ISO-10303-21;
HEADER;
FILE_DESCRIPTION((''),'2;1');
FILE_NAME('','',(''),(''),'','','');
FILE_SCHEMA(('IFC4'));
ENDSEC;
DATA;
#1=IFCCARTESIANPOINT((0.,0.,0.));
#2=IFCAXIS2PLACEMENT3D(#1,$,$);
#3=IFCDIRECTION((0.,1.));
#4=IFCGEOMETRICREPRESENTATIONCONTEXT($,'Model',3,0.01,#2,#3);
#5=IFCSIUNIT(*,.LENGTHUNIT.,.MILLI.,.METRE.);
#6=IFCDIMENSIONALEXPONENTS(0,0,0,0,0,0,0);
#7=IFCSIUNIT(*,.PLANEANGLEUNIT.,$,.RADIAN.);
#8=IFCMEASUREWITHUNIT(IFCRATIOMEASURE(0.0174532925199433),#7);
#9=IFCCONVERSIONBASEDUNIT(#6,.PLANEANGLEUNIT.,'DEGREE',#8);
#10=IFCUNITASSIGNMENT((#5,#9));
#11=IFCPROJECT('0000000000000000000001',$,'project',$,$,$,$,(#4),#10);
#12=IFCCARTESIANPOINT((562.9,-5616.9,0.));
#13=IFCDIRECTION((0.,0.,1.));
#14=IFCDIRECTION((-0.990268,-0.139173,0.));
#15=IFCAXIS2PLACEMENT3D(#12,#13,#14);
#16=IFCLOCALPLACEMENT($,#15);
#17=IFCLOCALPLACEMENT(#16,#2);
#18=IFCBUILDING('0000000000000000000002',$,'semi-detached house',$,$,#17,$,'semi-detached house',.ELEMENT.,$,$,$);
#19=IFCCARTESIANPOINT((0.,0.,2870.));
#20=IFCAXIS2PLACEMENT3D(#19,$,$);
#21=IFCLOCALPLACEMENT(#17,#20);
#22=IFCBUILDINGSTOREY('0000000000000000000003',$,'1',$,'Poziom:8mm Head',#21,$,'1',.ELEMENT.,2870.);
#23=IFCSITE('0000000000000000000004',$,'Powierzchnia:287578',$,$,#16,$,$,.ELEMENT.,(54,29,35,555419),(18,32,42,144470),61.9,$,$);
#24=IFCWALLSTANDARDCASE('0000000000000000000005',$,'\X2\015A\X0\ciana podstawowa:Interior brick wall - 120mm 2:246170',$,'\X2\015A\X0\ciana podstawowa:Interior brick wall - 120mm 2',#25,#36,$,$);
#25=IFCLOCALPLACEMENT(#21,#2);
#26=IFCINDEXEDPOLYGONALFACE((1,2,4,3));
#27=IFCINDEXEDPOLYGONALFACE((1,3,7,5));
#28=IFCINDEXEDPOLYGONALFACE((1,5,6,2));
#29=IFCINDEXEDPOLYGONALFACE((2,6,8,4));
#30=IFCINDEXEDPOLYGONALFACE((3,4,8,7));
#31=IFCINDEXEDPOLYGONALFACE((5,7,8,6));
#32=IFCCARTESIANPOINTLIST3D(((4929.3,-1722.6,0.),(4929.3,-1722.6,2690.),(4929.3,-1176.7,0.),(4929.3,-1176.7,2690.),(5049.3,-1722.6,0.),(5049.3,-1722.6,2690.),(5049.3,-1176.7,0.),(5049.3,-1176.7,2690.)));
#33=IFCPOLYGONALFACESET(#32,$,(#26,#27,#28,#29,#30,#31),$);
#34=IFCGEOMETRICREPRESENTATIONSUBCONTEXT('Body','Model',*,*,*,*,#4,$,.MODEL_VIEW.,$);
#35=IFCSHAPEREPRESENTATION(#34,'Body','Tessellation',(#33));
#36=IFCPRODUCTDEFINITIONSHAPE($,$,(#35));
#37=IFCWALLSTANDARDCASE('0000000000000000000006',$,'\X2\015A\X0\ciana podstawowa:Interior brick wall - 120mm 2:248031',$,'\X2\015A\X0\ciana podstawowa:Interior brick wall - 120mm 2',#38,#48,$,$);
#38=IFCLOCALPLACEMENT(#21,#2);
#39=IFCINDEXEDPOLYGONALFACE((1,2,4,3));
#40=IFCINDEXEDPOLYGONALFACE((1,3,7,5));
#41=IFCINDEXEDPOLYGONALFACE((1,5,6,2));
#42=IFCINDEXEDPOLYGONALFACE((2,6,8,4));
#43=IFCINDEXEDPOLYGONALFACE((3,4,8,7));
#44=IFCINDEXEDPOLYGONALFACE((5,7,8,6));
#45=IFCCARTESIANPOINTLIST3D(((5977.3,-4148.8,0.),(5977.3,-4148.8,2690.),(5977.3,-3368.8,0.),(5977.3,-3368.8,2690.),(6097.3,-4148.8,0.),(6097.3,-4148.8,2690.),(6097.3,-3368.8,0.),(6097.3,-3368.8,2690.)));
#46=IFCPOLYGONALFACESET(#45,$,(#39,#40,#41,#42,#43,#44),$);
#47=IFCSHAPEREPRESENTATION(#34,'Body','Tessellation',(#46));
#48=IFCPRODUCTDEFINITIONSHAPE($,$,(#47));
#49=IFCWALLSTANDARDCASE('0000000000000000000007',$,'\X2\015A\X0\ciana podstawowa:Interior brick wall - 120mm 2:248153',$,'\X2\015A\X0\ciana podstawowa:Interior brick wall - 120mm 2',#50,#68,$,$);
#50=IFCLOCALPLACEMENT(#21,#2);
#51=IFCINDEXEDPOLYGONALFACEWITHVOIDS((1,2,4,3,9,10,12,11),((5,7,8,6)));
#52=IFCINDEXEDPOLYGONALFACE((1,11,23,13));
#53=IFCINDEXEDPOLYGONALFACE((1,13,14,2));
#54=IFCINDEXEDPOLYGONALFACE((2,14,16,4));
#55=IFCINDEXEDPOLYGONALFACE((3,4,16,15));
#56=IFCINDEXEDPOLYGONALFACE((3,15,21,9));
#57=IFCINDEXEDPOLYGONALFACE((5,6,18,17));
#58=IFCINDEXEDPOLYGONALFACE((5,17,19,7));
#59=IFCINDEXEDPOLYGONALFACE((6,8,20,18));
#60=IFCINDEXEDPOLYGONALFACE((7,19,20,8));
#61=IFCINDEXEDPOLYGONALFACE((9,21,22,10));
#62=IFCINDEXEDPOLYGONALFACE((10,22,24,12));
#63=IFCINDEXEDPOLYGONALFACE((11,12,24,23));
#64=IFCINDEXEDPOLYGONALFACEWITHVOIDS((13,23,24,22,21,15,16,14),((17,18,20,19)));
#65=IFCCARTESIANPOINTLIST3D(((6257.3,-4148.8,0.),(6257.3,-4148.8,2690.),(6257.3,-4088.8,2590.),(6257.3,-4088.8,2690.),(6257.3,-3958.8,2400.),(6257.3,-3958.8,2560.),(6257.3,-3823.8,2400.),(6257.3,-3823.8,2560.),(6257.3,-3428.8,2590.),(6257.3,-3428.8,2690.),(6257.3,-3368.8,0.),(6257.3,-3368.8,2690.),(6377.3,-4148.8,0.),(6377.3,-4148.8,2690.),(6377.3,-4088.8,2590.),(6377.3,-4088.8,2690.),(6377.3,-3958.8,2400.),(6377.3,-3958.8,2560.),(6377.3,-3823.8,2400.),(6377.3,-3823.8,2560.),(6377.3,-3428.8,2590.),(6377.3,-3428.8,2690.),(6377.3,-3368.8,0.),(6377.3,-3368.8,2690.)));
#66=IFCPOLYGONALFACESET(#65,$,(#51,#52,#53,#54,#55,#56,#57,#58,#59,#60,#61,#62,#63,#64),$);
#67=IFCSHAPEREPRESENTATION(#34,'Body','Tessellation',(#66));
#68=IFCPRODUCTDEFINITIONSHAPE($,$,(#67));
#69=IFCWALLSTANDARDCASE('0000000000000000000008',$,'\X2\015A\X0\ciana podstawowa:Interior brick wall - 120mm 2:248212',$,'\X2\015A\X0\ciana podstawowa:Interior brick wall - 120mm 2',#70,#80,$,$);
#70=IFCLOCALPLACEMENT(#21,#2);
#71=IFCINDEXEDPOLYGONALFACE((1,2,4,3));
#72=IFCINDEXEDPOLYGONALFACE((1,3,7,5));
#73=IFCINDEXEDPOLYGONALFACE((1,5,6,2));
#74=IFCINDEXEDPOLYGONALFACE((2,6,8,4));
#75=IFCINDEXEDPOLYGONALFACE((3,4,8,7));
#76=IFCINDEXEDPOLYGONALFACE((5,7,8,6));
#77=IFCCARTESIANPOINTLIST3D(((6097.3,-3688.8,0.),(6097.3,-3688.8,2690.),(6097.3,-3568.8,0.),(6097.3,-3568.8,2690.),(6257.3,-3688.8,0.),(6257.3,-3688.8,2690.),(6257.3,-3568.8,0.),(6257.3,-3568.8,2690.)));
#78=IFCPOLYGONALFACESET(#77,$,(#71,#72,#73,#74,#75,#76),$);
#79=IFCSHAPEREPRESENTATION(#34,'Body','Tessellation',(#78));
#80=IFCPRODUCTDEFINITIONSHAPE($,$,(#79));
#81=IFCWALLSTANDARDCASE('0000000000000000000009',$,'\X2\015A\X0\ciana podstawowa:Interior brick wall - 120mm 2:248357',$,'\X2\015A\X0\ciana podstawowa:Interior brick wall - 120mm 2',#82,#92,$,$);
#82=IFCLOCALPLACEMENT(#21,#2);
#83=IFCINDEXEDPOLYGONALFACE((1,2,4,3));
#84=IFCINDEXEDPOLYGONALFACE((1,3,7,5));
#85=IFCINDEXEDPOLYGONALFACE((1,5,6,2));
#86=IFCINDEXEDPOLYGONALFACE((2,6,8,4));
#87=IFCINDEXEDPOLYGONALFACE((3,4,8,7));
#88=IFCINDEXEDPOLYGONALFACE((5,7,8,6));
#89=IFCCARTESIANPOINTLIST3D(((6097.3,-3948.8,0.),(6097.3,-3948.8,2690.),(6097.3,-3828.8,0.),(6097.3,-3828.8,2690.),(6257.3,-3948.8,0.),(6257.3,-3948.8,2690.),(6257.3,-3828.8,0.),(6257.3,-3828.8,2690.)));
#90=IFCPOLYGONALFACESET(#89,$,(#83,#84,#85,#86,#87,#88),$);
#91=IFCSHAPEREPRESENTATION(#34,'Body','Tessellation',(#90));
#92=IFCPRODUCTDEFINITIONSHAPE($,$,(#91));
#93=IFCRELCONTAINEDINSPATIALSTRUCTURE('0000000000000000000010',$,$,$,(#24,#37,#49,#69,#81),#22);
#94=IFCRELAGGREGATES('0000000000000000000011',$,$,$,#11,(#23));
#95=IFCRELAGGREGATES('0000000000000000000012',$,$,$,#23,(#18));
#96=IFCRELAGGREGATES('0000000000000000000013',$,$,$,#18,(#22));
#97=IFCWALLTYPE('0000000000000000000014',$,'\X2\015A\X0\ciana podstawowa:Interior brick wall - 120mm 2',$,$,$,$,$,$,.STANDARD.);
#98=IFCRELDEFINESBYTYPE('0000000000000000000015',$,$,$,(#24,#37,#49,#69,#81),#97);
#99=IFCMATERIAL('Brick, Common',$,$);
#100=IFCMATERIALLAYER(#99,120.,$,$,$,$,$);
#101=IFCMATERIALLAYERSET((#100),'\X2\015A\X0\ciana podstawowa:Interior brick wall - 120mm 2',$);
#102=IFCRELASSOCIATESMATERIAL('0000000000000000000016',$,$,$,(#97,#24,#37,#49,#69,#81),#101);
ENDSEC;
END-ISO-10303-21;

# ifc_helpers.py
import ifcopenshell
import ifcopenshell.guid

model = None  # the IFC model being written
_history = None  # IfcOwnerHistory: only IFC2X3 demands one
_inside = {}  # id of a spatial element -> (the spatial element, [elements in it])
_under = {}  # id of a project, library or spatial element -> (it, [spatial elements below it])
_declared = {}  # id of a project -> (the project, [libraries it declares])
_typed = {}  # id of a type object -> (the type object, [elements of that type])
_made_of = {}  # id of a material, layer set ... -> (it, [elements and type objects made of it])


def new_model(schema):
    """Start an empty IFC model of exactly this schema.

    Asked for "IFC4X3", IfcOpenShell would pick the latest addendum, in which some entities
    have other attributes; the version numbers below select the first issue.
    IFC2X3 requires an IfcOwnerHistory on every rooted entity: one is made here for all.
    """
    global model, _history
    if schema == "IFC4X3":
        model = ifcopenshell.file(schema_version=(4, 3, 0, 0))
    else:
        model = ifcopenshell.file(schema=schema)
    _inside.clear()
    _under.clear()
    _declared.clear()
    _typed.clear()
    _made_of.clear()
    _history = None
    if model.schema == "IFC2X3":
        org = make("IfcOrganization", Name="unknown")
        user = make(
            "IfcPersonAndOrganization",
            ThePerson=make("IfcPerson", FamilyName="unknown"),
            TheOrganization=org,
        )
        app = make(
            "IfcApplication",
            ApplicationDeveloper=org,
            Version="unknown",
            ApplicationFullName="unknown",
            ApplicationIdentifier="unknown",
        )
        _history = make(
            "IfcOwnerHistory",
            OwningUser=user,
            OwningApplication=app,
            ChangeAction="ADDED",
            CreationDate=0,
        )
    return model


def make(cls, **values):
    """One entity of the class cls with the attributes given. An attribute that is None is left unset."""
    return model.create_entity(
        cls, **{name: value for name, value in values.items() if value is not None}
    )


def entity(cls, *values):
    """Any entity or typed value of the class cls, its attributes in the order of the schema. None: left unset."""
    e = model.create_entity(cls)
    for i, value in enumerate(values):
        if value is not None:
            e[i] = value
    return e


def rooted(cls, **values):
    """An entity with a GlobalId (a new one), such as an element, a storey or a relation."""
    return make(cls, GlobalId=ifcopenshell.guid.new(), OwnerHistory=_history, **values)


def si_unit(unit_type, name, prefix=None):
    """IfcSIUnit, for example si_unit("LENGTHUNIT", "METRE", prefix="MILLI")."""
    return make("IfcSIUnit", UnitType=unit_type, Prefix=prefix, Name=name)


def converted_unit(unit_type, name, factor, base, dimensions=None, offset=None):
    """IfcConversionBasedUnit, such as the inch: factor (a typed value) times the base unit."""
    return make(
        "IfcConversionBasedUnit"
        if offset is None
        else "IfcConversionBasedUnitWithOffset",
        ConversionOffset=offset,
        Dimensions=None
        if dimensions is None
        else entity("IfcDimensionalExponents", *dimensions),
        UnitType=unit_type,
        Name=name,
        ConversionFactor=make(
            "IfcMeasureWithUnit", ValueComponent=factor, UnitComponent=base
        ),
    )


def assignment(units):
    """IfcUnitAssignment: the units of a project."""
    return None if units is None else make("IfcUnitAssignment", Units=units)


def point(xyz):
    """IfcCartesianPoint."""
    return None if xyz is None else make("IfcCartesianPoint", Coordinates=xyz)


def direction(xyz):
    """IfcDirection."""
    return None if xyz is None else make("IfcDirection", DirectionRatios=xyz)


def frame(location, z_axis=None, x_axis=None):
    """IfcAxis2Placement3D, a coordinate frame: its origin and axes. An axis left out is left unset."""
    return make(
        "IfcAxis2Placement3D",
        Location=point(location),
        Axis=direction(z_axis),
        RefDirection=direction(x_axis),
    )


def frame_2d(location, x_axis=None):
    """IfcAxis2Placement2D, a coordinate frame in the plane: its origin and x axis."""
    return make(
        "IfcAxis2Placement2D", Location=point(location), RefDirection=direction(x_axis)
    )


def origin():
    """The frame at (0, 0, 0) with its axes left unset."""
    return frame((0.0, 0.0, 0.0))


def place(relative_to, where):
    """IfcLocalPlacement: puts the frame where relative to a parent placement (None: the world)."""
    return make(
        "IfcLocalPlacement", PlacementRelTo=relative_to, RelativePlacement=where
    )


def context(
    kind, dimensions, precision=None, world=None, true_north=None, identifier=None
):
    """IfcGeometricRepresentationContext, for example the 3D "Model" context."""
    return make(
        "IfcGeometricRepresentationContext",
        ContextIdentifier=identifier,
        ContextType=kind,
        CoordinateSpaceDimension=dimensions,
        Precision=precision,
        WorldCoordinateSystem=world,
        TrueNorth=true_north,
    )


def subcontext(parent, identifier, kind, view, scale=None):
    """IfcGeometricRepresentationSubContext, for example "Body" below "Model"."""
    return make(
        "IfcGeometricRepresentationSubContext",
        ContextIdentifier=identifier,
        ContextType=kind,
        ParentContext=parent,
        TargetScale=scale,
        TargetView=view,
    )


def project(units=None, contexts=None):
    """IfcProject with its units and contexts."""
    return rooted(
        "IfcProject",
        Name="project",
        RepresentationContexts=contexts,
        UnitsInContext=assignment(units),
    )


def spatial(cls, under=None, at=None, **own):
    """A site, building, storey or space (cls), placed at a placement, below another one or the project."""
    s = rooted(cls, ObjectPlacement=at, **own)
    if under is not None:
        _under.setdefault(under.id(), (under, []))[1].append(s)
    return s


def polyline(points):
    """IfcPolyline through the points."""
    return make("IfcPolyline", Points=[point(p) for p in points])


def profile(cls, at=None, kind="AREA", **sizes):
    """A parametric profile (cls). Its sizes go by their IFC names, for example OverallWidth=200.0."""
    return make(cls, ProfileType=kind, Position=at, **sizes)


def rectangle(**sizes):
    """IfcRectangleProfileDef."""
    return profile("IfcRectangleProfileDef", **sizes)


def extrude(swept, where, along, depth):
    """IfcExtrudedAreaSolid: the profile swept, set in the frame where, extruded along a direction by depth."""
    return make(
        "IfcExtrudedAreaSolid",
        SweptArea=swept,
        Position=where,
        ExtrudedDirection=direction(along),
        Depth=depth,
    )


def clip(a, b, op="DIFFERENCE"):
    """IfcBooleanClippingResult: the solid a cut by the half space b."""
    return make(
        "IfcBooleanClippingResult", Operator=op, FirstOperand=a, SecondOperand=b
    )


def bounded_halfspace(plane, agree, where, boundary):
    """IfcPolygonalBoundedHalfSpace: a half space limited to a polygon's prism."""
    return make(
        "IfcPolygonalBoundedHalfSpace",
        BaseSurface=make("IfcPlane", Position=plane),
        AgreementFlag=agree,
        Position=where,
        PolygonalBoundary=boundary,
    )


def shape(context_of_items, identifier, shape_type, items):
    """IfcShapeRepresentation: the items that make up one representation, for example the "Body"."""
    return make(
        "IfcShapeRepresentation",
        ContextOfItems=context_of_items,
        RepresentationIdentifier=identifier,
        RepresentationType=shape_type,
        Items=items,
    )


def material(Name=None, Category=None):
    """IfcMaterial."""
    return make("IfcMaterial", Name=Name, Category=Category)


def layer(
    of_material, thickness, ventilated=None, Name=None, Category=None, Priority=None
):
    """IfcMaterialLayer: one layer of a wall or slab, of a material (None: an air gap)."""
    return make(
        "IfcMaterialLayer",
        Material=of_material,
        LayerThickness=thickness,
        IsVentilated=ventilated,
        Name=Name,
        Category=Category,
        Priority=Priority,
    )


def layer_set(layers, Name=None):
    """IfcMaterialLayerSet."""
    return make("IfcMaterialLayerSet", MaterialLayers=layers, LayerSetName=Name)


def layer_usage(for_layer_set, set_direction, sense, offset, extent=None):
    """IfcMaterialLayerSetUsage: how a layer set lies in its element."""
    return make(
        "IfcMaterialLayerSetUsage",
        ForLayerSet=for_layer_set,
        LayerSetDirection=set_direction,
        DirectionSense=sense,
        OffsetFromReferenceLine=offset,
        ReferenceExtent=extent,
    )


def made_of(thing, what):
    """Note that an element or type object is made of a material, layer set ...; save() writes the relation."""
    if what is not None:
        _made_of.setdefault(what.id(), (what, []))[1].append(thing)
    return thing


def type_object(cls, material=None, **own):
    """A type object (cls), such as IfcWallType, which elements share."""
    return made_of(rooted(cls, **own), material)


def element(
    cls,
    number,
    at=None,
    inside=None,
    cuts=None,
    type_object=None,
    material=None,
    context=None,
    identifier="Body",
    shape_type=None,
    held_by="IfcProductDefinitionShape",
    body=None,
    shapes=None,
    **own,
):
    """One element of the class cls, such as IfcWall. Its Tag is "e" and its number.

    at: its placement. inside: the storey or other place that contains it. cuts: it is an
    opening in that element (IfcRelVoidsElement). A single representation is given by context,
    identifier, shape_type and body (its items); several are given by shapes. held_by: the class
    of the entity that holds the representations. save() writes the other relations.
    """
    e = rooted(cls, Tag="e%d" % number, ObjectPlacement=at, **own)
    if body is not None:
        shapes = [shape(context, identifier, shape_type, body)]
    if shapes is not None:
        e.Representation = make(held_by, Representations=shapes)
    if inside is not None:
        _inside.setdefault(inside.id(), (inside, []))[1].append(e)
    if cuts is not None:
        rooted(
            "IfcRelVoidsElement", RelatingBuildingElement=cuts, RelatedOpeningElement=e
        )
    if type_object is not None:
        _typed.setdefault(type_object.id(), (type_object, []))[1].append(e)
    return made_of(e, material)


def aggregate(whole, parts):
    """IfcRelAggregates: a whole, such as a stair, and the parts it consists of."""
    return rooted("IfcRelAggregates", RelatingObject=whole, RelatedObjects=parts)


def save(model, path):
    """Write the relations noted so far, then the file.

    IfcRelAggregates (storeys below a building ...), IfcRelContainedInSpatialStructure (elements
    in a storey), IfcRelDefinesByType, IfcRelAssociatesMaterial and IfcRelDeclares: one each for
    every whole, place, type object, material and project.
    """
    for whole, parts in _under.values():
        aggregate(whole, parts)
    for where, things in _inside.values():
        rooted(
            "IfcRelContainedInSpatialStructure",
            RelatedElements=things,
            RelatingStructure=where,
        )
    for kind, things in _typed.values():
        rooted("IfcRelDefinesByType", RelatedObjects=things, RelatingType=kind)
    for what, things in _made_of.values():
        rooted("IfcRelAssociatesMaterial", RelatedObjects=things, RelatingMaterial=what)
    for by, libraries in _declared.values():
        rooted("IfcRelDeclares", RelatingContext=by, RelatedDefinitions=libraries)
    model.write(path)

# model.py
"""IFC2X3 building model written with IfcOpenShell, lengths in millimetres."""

from ifc_helpers import new_model, entity, si_unit, converted_unit, direction, frame, frame_2d, origin, place, context, subcontext, project, spatial, polyline, rectangle, extrude, clip, bounded_halfspace, material, layer, layer_set, layer_usage, type_object, element, save


model = new_model("IFC2X3")

# Units and contexts
model_context = context("Model", 3, precision=0.01, world=origin(), true_north=direction((0.0, 1.0)))
body_context = subcontext(model_context, "Body", "Model", "MODEL_VIEW")
ifc_project = project(units=[si_unit("LENGTHUNIT", "METRE", prefix="MILLI"), converted_unit("PLANEANGLEUNIT", "DEGREE", entity("IfcRatioMeasure", 0.0174532925199433), si_unit("PLANEANGLEUNIT", "RADIAN"), dimensions=[0, 0, 0, 0, 0, 0, 0])], contexts=[model_context])

# Site, building, storey
site_placement = place(None, frame((562.9, -5616.9, 0.0), z_axis=(0.0, 0.0, 1.0), x_axis=(-0.990268, -0.139173, 0.0)))
site = spatial("IfcSite", under=ifc_project, at=site_placement, Name="Powierzchnia:287578", CompositionType="ELEMENT", RefLatitude=(54, 29, 35, 555419), RefLongitude=(18, 32, 42, 144470), RefElevation=61.9)
building_placement = place(site_placement, origin())
building = spatial("IfcBuilding", under=site, at=building_placement, Name="semi-detached house", LongName="semi-detached house", CompositionType="ELEMENT")
storey_placement = place(building_placement, frame((0.0, 0.0, 2870.0)))
storey = spatial("IfcBuildingStorey", under=building, at=storey_placement, Name="1", ObjectType="Poziom:8mm Head", LongName="1", CompositionType="ELEMENT", Elevation=2870.0)

# Shared definitions
ifc_material_1 = material(Name="Brick, Common")

# Shared definitions
ifc_layer_1 = layer(ifc_material_1, 120.0)
ifc_layer_set_1 = layer_set([ifc_layer_1], Name="Ściana podstawowa:Interior brick wall - 120mm 2")
wall_type_1 = type_object("IfcWallType", Name="Ściana podstawowa:Interior brick wall - 120mm 2", PredefinedType="STANDARD", material=ifc_layer_set_1)

# Walls
ifc_layer_usage_1 = layer_usage(ifc_layer_set_1, "AXIS2", "POSITIVE", -60.0)
wall_1_placement = place(storey_placement, frame((4989.3, -1176.7, 0.0), z_axis=(0.0, 0.0, 1.0), x_axis=(0.0, -1.0, 0.0)))
element("IfcWallStandardCase", 1, at=wall_1_placement, inside=storey, type_object=wall_type_1, material=ifc_layer_usage_1, Name="Ściana podstawowa:Interior brick wall - 120mm 2:246170", ObjectType="Ściana podstawowa:Interior brick wall - 120mm 2", context=body_context, shape_type="Clipping", body=[
    clip(extrude(rectangle(XDim=546.0, YDim=120.0, at=frame_2d((273.0, 0.0), x_axis=(-1.0, 0.0))), origin(), (0.0, 0.0, 1.0), 2690.0), bounded_halfspace(frame((546.0, -60.0, 0.0), z_axis=(0.0, 0.0, 1.0), x_axis=(0.0, -1.0, 0.0)), True, frame((546.0, -60.0, 0.0), z_axis=(0.0, 0.0, 1.0), x_axis=(0.0, -1.0, 0.0)), polyline([(0.0, 0.0), (-120.0, 0.0), (-120.0, -276.0), (-120.0, -546.0), (0.0, -546.0), (0.0, -458.9), (0.0, -338.9), (0.0, -198.9), (0.0, -78.9), (0.0, 0.0)]))),
])
ifc_layer_usage_2 = layer_usage(ifc_layer_set_1, "AXIS2", "POSITIVE", -60.0)
wall_2_placement = place(storey_placement, frame((6037.3, -3368.8, 0.0), z_axis=(0.0, 0.0, 1.0), x_axis=(0.0, -1.0, 0.0)))
element("IfcWallStandardCase", 2, at=wall_2_placement, inside=storey, type_object=wall_type_1, material=ifc_layer_usage_2, Name="Ściana podstawowa:Interior brick wall - 120mm 2:248031", ObjectType="Ściana podstawowa:Interior brick wall - 120mm 2", context=body_context, shape_type="SweptSolid", body=[
    extrude(rectangle(XDim=780.0, YDim=120.0, at=frame_2d((390.0, 0.0), x_axis=(-1.0, 0.0))), origin(), (0.0, 0.0, 1.0), 2690.0),
])

# Wall, opening
ifc_layer_usage_3 = layer_usage(ifc_layer_set_1, "AXIS2", "NEGATIVE", 60.0)
wall_3_placement = place(storey_placement, frame((6317.3, -3368.8, 0.0), z_axis=(0.0, 0.0, 1.0), x_axis=(0.0, -1.0, 0.0)))
wall_3 = element("IfcWallStandardCase", 3, at=wall_3_placement, inside=storey, type_object=wall_type_1, material=ifc_layer_usage_3, Name="Ściana podstawowa:Interior brick wall - 120mm 2:248153", ObjectType="Ściana podstawowa:Interior brick wall - 120mm 2", context=body_context, shape_type="Clipping", body=[
    clip(extrude(rectangle(XDim=780.0, YDim=120.0, at=frame_2d((390.0, 0.0), x_axis=(-1.0, 0.0))), origin(), (0.0, 0.0, 1.0), 2690.0), bounded_halfspace(frame((720.0, -60.0, 2590.0), z_axis=(0.0, 0.0, -1.0), x_axis=(0.0, -1.0, 0.0)), True, frame((720.0, -60.0, 2590.0), z_axis=(0.0, 0.0, -1.0), x_axis=(0.0, -1.0, 0.0)), polyline([(0.0, 0.0), (0.0, 660.0), (-120.0, 660.0), (-120.0, 0.0), (0.0, 0.0)]))),
])
opening_1_placement = place(wall_3_placement, origin())
element("IfcOpeningElement", 4, at=opening_1_placement, cuts=wall_3, ObjectType="Opening", context=body_context, shape_type="SweptSolid", body=[
    extrude(rectangle(XDim=160.0, YDim=135.0, at=frame_2d((0.0, 0.0), x_axis=(1.0, 0.0))), frame((522.5, -60.0, 2480.0), z_axis=(0.0, 1.0, 0.0), x_axis=(0.0, 0.0, -1.0)), (0.0, 0.0, 1.0), 120.0),
])

# Walls
ifc_layer_usage_4 = layer_usage(ifc_layer_set_1, "AXIS2", "NEGATIVE", 60.0)
wall_4_placement = place(storey_placement, frame((6097.3, -3628.8, 0.0)))
element("IfcWallStandardCase", 5, at=wall_4_placement, inside=storey, type_object=wall_type_1, material=ifc_layer_usage_4, Name="Ściana podstawowa:Interior brick wall - 120mm 2:248212", ObjectType="Ściana podstawowa:Interior brick wall - 120mm 2", context=body_context, shape_type="SweptSolid", body=[
    extrude(rectangle(XDim=160.0, YDim=120.0, at=frame_2d((80.0, 0.0), x_axis=(-1.0, 0.0))), origin(), (0.0, 0.0, 1.0), 2690.0),
])
ifc_layer_usage_5 = layer_usage(ifc_layer_set_1, "AXIS2", "NEGATIVE", 60.0)
wall_5_placement = place(storey_placement, frame((6097.3, -3888.8, 0.0)))
element("IfcWallStandardCase", 6, at=wall_5_placement, inside=storey, type_object=wall_type_1, material=ifc_layer_usage_5, Name="Ściana podstawowa:Interior brick wall - 120mm 2:248357", ObjectType="Ściana podstawowa:Interior brick wall - 120mm 2", context=body_context, shape_type="SweptSolid", body=[
    extrude(rectangle(XDim=160.0, YDim=120.0, at=frame_2d((80.0, 0.0), x_axis=(-1.0, 0.0))), origin(), (0.0, 0.0, 1.0), 2690.0),
])

save(model, "model.ifc")
